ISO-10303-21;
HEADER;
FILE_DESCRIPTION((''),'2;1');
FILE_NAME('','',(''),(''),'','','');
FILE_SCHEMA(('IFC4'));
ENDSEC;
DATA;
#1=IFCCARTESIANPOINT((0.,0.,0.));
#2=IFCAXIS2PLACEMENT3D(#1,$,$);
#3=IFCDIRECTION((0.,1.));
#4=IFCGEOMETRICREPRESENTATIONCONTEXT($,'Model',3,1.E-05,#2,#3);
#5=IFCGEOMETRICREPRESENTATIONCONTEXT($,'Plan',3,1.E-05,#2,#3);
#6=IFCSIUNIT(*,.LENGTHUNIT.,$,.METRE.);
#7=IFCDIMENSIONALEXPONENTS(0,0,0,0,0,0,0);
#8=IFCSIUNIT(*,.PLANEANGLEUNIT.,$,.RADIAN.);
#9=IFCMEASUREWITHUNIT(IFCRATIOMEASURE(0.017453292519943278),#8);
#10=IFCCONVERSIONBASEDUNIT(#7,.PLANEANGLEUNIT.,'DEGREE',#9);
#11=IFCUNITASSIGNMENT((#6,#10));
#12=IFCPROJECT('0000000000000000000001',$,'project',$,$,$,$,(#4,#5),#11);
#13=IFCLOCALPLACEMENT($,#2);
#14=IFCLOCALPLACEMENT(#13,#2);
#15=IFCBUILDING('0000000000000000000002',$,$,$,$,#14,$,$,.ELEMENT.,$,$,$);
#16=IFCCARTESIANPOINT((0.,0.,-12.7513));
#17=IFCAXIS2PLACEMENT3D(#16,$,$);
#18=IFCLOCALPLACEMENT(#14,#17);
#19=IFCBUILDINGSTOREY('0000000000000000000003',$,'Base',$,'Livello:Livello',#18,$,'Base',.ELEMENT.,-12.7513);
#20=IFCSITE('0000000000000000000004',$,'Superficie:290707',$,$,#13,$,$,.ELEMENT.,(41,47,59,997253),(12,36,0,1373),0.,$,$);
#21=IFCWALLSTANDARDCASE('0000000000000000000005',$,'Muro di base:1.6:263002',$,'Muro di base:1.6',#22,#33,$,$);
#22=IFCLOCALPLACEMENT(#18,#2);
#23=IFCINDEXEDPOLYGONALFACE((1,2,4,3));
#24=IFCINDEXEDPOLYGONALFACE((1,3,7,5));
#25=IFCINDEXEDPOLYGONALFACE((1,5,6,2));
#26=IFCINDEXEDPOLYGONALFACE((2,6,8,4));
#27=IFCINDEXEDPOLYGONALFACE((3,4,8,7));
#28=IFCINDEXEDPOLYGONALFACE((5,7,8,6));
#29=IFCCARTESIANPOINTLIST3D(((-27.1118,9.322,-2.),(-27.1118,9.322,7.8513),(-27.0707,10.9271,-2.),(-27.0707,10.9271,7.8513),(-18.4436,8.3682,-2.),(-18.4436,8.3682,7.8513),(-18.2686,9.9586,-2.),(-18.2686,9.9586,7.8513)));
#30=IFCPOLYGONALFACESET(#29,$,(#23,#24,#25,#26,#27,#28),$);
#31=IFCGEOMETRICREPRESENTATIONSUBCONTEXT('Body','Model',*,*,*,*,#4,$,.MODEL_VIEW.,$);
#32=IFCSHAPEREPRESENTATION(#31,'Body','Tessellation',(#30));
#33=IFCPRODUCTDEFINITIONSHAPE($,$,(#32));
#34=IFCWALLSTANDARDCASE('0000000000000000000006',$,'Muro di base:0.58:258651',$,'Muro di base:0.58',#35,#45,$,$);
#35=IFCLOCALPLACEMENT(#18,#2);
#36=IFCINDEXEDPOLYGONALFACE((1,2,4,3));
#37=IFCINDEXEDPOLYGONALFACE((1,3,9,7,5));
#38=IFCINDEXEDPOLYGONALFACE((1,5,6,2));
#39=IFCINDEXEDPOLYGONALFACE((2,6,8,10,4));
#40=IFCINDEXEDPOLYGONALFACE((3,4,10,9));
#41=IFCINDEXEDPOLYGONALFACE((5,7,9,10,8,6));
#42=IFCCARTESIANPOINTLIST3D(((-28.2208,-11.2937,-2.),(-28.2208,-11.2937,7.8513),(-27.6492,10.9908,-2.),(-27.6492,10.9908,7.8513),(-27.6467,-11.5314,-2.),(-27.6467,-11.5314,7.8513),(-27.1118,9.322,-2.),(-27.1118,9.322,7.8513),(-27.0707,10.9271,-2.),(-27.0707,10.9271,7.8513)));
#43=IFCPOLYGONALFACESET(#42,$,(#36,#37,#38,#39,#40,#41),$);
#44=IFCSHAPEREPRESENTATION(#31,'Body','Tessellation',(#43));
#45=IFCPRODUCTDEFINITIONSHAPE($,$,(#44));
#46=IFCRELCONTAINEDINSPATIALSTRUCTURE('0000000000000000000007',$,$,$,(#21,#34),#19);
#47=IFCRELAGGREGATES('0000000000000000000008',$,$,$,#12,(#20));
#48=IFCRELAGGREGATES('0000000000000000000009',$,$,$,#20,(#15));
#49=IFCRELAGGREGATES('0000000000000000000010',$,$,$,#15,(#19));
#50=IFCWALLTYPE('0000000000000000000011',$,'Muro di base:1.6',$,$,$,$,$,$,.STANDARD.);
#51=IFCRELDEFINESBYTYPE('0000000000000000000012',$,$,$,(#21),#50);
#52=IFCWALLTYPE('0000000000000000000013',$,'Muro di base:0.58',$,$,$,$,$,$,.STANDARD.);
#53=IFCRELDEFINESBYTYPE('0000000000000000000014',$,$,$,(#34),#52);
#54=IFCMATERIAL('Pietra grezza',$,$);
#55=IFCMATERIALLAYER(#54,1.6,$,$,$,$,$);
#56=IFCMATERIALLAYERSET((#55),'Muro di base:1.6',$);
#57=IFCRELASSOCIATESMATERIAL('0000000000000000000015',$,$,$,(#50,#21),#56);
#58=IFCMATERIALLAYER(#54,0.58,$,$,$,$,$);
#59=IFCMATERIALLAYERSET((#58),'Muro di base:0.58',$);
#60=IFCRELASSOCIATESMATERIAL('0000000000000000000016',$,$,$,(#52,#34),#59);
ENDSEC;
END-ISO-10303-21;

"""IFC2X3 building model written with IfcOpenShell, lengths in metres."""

from ifc_helpers import new_model, entity, si_unit, converted_unit, direction, frame, origin, place, context, subcontext, project, spatial, polyline, outline, extrude, material, layer, layer_set, layer_usage, type_object, element, save


model = new_model("IFC2X3")

# Units and contexts
model_context = context("Model", 3, precision=1e-05, world=origin(), true_north=direction((0.0, 1.0)))
plan_context = context("Plan", 3, precision=1e-05, world=origin(), true_north=direction((0.0, 1.0)))
body_context = subcontext(model_context, "Body", "Model", "MODEL_VIEW")
ifc_project = project(units=[si_unit("LENGTHUNIT", "METRE"), converted_unit("PLANEANGLEUNIT", "DEGREE", entity("IfcRatioMeasure", 0.017453292519943278), si_unit("PLANEANGLEUNIT", "RADIAN"), dimensions=[0, 0, 0, 0, 0, 0, 0])], contexts=[model_context, plan_context])

# Site, building, storey
site_placement = place(None, origin())
site = spatial("IfcSite", under=ifc_project, at=site_placement, Name="Superficie:290707", CompositionType="ELEMENT", RefLatitude=(41, 47, 59, 997253), RefLongitude=(12, 36, 0, 1373), RefElevation=0.0)
building_placement = place(site_placement, origin())
building = spatial("IfcBuilding", under=site, at=building_placement, CompositionType="ELEMENT")
storey_placement = place(building_placement, frame((0.0, 0.0, -12.7513)))
storey = spatial("IfcBuildingStorey", under=building, at=storey_placement, Name="Base", ObjectType="Livello:Livello", LongName="Base", CompositionType="ELEMENT", Elevation=-12.7513)

# Wall
ifc_material = material(Name="Pietra grezza")
ifc_layer_1 = layer(ifc_material, 1.6)
ifc_layer_set_1 = layer_set([ifc_layer_1], Name="Muro di base:1.6")
ifc_layer_usage_1 = layer_usage(ifc_layer_set_1, "AXIS2", "POSITIVE", -0.8)
wall_type_1 = type_object("IfcWallType", Name="Muro di base:1.6", PredefinedType="STANDARD", material=ifc_layer_set_1)
wall_1_placement = place(storey_placement, frame((-27.1582, 10.1319, -2.0), z_axis=(0.0, 0.0, 1.0), x_axis=(0.994001, -0.109375, 0.0)))
element("IfcWallStandardCase", 1, at=wall_1_placement, inside=storey, type_object=wall_type_1, material=ifc_layer_usage_1, Name="Muro di base:1.6:263002", ObjectType="Muro di base:1.6", context=body_context, shape_type="SweptSolid", body=[
    extrude(outline(polyline([(8.8552, -0.8), (8.8552, 0.8), (0.0, 0.8), (0.1346, -0.8), (8.8552, -0.8)])), origin(), (0.0, 0.0, 1.0), 9.8513),
])

# Wall
ifc_layer_2 = layer(ifc_material, 0.58)
ifc_layer_set_2 = layer_set([ifc_layer_2], Name="Muro di base:0.58")
ifc_layer_usage_2 = layer_usage(ifc_layer_set_2, "AXIS2", "NEGATIVE", 0.29)
wall_type_2 = type_object("IfcWallType", Name="Muro di base:0.58", PredefinedType="STANDARD", material=ifc_layer_set_2)
wall_2_placement = place(storey_placement, frame((-27.9366, -11.5239, -2.0), z_axis=(0.0, 0.0, 1.0), x_axis=(0.02564, 0.999671, 0.0)))
element("IfcWallStandardCase", 2, at=wall_2_placement, inside=storey, type_object=wall_type_2, material=ifc_layer_usage_2, Name="Muro di base:0.58:258651", ObjectType="Muro di base:0.58", context=body_context, shape_type="SweptSolid", body=[
    extrude(outline(polyline([(22.4659, -0.29), (22.5147, 0.29), (0.2228, 0.29), (0.0, -0.29), (20.8602, -0.29), (22.4659, -0.29)])), origin(), (0.0, 0.0, 1.0), 9.8513),
])

save(model, "model.ifc")
